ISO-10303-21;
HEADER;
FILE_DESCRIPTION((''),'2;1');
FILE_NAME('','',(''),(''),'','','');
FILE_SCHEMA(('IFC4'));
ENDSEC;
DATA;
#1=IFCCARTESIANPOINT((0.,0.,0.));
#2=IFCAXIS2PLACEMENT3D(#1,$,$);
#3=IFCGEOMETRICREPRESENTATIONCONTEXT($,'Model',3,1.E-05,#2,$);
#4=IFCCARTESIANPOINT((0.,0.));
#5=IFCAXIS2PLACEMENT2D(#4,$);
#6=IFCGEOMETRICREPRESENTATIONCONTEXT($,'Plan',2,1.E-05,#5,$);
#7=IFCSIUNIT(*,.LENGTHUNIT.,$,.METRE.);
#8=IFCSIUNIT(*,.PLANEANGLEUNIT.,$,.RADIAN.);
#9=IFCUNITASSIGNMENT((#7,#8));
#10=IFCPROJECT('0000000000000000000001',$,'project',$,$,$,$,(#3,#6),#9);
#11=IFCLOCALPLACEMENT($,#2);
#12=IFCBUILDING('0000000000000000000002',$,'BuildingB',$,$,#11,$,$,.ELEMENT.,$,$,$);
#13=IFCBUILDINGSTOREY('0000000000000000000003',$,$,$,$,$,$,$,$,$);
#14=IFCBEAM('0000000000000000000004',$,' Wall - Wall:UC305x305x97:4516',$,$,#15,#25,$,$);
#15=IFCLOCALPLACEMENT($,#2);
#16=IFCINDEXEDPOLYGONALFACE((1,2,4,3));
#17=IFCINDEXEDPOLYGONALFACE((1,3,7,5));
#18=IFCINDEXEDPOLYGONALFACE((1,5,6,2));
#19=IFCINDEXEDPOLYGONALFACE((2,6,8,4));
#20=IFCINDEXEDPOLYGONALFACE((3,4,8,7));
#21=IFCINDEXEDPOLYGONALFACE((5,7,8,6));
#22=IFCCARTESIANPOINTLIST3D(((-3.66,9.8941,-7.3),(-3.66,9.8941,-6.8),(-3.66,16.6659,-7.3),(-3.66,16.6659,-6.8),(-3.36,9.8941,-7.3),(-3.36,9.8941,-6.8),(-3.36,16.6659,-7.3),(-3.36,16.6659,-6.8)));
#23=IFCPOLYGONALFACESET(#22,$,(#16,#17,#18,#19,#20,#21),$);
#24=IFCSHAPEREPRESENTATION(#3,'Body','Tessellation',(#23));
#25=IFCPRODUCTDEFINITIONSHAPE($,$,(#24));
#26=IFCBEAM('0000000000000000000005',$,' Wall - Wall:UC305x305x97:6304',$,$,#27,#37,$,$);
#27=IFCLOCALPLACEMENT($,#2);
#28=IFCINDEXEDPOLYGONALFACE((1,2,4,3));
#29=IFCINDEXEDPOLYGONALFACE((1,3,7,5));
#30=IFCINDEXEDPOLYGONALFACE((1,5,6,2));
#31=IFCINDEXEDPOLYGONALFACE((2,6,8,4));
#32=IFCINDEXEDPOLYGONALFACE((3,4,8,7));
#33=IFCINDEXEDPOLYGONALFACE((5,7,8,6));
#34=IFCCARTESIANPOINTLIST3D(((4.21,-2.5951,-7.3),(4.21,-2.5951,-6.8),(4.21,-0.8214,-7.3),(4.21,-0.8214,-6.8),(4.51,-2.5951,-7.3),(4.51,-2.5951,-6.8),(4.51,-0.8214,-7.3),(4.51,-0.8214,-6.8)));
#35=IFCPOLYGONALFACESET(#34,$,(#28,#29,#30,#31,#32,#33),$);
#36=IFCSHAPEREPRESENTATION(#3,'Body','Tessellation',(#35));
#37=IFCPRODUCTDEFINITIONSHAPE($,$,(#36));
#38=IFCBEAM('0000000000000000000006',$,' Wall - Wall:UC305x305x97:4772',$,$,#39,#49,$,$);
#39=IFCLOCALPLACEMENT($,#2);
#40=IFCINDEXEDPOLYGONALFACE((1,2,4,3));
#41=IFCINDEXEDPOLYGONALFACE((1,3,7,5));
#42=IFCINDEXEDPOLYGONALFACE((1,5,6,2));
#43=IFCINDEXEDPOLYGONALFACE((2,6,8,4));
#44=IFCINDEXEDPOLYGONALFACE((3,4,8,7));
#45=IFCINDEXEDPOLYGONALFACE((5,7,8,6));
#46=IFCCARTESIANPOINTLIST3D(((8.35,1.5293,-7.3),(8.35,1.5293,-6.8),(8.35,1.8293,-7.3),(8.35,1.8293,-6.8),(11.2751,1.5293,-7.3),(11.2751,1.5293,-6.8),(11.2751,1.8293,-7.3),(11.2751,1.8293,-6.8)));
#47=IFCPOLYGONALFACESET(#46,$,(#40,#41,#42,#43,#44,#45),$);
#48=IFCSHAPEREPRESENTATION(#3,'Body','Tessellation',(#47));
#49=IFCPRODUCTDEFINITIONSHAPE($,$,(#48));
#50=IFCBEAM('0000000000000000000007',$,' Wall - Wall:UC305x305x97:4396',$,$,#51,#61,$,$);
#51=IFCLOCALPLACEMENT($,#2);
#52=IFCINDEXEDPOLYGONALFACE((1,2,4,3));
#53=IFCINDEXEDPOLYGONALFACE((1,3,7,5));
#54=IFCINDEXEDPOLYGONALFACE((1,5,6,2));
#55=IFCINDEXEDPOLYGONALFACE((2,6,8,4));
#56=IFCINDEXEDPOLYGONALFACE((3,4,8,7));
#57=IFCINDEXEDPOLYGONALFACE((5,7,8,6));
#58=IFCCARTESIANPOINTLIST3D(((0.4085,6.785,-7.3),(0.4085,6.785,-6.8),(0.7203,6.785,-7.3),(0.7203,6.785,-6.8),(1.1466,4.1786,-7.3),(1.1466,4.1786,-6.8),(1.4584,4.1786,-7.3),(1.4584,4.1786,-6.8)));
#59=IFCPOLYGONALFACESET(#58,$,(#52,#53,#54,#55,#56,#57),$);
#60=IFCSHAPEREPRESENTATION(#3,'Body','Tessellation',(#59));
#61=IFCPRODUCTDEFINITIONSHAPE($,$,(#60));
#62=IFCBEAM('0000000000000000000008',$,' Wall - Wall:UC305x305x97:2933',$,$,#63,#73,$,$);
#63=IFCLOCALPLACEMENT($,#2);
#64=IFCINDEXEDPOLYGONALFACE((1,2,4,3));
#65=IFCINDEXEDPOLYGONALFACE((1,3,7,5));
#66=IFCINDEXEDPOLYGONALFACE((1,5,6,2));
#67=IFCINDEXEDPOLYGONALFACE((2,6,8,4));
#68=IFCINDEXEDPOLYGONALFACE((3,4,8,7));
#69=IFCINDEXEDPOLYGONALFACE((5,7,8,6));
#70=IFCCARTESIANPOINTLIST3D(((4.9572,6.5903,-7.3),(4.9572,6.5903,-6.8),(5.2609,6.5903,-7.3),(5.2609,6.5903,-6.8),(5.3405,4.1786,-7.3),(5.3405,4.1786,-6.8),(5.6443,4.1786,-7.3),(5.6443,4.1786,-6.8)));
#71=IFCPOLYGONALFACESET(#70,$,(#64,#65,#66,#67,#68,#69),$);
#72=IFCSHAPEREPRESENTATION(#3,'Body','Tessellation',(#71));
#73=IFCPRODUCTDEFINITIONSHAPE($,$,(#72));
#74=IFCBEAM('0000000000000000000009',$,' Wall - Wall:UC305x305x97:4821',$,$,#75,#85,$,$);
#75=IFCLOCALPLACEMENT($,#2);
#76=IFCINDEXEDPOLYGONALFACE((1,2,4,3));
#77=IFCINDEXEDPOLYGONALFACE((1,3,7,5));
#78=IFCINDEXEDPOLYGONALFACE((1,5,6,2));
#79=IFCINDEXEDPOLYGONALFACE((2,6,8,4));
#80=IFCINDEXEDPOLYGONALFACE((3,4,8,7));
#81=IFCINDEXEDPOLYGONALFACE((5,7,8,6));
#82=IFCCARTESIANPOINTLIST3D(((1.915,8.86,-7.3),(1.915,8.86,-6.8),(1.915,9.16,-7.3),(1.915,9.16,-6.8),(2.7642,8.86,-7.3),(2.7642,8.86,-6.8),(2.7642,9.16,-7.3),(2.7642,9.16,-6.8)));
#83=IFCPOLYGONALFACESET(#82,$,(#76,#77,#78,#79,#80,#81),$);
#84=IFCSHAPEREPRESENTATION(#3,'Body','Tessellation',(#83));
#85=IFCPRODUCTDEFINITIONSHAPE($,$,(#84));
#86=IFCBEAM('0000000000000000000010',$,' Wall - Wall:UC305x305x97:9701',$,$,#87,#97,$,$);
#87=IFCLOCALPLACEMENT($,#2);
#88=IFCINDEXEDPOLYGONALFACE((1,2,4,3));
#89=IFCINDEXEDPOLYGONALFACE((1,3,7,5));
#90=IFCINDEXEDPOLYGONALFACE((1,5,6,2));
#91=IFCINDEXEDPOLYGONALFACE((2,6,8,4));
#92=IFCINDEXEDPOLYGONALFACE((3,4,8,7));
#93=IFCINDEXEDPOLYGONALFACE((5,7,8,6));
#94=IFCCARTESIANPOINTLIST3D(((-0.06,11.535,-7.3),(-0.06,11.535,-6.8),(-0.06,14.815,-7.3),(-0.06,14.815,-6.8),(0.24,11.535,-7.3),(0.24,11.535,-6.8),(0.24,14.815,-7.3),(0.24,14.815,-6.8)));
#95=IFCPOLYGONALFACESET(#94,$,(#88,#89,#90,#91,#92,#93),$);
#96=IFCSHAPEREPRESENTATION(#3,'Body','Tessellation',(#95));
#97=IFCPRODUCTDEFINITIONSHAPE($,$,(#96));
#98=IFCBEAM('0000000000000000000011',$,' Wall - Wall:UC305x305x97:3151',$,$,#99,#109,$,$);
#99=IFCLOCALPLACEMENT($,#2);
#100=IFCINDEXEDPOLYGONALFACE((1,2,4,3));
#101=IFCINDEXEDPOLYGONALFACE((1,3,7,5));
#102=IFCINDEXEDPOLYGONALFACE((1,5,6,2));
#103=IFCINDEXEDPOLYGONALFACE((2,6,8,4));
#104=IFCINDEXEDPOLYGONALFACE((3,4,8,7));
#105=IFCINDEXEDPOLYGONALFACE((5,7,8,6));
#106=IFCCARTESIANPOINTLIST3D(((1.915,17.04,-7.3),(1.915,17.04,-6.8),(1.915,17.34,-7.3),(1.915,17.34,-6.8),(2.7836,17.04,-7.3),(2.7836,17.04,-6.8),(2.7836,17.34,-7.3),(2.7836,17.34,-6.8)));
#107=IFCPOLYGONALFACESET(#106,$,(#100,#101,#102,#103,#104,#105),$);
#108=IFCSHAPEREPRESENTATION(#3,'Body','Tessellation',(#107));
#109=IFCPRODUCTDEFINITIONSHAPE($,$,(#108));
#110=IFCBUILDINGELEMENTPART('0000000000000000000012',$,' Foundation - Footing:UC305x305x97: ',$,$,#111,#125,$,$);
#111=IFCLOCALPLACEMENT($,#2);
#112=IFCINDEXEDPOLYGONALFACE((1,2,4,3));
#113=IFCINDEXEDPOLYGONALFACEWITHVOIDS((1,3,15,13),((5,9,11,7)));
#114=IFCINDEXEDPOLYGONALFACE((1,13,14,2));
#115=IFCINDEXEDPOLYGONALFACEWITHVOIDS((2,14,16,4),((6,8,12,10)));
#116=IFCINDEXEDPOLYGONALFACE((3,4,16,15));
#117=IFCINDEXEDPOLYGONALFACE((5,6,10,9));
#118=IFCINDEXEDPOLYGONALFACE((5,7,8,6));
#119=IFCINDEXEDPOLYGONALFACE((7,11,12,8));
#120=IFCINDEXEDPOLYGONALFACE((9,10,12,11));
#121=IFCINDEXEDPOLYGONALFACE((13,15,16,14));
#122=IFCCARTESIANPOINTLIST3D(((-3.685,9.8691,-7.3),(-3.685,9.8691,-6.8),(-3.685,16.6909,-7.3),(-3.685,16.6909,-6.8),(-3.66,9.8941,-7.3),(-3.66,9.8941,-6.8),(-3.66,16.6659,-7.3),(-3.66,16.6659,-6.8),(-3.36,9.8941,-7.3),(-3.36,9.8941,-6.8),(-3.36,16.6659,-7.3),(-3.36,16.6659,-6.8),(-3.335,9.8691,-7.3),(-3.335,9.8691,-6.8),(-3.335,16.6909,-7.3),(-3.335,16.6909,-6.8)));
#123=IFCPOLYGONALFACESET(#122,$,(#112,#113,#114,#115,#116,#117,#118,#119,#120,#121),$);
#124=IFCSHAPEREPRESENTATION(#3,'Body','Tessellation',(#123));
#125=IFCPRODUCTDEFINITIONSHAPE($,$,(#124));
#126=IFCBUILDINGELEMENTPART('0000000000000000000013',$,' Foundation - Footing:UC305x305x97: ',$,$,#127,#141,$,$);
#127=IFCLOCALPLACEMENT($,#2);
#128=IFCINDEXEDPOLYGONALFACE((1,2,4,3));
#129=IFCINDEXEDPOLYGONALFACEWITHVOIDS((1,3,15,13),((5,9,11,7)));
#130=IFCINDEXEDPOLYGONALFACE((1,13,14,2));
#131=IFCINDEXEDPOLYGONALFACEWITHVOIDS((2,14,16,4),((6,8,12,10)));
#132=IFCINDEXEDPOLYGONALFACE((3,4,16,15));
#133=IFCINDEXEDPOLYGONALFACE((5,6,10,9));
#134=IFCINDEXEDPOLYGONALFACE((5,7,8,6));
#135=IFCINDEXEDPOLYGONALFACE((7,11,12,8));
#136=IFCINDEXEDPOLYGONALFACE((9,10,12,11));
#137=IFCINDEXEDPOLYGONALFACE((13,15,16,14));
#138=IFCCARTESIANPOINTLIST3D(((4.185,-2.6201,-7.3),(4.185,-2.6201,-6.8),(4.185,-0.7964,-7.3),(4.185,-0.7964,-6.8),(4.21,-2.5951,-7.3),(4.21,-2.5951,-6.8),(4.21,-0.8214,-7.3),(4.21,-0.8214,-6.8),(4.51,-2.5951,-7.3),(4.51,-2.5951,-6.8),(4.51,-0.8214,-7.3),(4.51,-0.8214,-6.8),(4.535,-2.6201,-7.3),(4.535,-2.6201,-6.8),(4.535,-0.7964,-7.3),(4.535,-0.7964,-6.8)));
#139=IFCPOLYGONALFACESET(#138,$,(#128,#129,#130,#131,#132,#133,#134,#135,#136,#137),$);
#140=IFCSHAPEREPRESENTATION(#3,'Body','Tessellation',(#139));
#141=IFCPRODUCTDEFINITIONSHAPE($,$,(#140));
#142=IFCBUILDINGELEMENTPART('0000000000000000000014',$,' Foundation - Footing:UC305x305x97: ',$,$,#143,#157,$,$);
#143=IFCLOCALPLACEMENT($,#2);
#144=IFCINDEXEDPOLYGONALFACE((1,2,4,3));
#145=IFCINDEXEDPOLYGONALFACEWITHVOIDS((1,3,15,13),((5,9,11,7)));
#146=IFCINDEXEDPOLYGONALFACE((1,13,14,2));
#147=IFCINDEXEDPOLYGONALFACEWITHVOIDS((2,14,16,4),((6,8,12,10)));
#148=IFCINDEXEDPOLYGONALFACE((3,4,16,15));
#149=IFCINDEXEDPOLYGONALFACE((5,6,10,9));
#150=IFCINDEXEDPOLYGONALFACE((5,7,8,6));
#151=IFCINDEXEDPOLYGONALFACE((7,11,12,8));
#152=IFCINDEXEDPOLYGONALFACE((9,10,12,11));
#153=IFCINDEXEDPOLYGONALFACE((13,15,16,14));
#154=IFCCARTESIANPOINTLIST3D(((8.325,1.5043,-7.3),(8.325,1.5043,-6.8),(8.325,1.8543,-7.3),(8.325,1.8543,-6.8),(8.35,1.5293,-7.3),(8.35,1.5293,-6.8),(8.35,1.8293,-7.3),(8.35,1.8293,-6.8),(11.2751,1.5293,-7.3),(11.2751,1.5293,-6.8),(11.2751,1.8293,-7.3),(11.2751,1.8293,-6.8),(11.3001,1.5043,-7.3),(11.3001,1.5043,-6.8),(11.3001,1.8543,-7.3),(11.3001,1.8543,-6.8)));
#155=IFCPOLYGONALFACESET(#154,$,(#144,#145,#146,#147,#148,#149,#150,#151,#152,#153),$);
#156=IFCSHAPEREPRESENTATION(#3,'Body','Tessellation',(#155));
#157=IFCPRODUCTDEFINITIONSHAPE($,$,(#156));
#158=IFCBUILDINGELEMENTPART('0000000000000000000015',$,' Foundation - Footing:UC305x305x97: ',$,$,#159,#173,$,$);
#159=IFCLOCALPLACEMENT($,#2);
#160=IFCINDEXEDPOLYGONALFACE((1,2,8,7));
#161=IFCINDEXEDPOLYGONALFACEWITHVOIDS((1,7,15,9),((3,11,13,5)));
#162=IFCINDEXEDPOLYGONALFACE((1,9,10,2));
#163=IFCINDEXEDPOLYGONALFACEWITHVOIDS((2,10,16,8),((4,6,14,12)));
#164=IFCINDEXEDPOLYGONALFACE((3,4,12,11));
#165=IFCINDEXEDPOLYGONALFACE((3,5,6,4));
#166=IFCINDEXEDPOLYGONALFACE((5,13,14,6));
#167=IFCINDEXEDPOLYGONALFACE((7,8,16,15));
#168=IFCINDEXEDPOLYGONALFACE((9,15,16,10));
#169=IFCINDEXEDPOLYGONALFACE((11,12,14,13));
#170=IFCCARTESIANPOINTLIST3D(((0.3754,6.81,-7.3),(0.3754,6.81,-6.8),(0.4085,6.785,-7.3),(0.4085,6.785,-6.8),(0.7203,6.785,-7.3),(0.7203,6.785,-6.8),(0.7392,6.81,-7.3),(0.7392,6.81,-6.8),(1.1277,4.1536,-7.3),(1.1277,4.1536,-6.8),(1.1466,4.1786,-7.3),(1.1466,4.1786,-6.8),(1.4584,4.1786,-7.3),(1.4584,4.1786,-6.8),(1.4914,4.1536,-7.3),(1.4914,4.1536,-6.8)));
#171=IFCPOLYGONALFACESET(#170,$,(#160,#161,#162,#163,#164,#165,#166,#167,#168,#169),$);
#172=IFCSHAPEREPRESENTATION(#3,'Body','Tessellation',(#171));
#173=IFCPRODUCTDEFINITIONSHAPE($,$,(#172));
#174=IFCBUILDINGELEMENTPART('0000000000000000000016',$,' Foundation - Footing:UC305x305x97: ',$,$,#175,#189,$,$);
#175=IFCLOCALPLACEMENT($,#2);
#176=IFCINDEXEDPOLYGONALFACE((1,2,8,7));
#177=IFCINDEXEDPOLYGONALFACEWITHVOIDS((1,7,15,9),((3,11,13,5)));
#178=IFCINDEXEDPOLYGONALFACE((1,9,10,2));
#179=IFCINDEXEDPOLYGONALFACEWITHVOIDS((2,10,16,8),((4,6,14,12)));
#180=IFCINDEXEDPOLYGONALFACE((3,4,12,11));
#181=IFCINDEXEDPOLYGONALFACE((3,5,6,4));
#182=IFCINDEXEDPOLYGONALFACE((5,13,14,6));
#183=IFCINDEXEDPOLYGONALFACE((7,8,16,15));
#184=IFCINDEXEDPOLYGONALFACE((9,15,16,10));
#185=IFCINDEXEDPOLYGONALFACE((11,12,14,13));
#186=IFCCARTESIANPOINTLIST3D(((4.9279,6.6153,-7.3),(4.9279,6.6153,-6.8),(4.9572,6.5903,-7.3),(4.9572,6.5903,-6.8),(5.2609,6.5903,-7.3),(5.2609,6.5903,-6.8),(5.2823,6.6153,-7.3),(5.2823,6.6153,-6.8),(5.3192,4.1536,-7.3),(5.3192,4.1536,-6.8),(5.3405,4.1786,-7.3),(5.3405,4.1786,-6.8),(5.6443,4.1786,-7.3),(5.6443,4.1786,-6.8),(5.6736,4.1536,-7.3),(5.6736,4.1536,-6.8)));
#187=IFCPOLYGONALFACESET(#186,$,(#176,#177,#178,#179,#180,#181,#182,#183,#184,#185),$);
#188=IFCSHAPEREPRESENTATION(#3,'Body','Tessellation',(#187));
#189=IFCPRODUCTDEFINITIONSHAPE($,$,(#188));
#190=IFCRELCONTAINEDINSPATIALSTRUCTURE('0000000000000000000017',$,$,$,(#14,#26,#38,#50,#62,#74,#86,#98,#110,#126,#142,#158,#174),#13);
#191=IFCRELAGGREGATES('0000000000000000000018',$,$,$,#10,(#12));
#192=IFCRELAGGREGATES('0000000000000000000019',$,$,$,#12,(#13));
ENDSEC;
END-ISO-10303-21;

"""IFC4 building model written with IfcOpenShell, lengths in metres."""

from ifc_helpers import new_model, si_unit, origin, origin_2d, place, context, project, spatial, polyline, outline, extrude, element, save


model = new_model("IFC4")

# Units and contexts
model_context = context("Model", 3, precision=1e-05, world=origin())
plan_context = context("Plan", 2, precision=1e-05, world=origin_2d())
ifc_project = project(units=[si_unit("LENGTHUNIT", "METRE"), si_unit("PLANEANGLEUNIT", "RADIAN")], contexts=[model_context, plan_context])

# Building, storey
building_placement = place(None, origin())
building = spatial("IfcBuilding", under=ifc_project, at=building_placement, Name="BuildingB", CompositionType="ELEMENT")
storey = spatial("IfcBuildingStorey", under=building)

# Beams
element("IfcBeam", 1, inside=storey, Name=" Wall - Wall:UC305x305x97:4516", context=model_context, shape_type="SweptSolid", body=[
    extrude(outline(polyline([(-3.66, 9.8941, -7.3), (-3.36, 9.8941, -7.3), (-3.36, 16.6659, -7.3), (-3.66, 16.6659, -7.3), (-3.66, 9.8941, -7.3)])), None, (0.0, 0.0, 1.0), 0.5),
])
element("IfcBeam", 2, inside=storey, Name=" Wall - Wall:UC305x305x97:6304", context=model_context, shape_type="SweptSolid", body=[
    extrude(outline(polyline([(4.21, -2.5951, -7.3), (4.51, -2.5951, -7.3), (4.51, -0.8214, -7.3), (4.21, -0.8214, -7.3), (4.21, -2.5951, -7.3)])), None, (0.0, 0.0, 1.0), 0.5),
])
element("IfcBeam", 3, inside=storey, Name=" Wall - Wall:UC305x305x97:4772", context=model_context, shape_type="SweptSolid", body=[
    extrude(outline(polyline([(8.35, 1.5293, -7.3), (8.35, 1.8293, -7.3), (11.2751, 1.8293, -7.3), (11.2751, 1.5293, -7.3), (8.35, 1.5293, -7.3)])), None, (0.0, 0.0, 1.0), 0.5),
])
element("IfcBeam", 4, inside=storey, Name=" Wall - Wall:UC305x305x97:4396", context=model_context, shape_type="SweptSolid", body=[
    extrude(outline(polyline([(1.1466, 4.1786, -7.3), (0.4085, 6.785, -7.3), (0.7203, 6.785, -7.3), (1.4584, 4.1786, -7.3), (1.1466, 4.1786, -7.3)])), None, (0.0, 0.0, 1.0), 0.5),
])
element("IfcBeam", 5, inside=storey, Name=" Wall - Wall:UC305x305x97:2933", context=model_context, shape_type="SweptSolid", body=[
    extrude(outline(polyline([(5.3405, 4.1786, -7.3), (4.9572, 6.5903, -7.3), (5.2609, 6.5903, -7.3), (5.6443, 4.1786, -7.3), (5.3405, 4.1786, -7.3)])), None, (0.0, 0.0, 1.0), 0.5),
])
element("IfcBeam", 6, inside=storey, Name=" Wall - Wall:UC305x305x97:4821", context=model_context, shape_type="SweptSolid", body=[
    extrude(outline(polyline([(1.915, 8.86, -7.3), (1.915, 9.16, -7.3), (2.7642, 9.16, -7.3), (2.7642, 8.86, -7.3), (1.915, 8.86, -7.3)])), None, (0.0, 0.0, 1.0), 0.5),
])
element("IfcBeam", 7, inside=storey, Name=" Wall - Wall:UC305x305x97:9701", context=model_context, shape_type="SweptSolid", body=[
    extrude(outline(polyline([(-0.06, 11.535, -7.3), (-0.06, 14.815, -7.3), (0.24, 14.815, -7.3), (0.24, 11.535, -7.3), (-0.06, 11.535, -7.3)])), None, (0.0, 0.0, 1.0), 0.5),
])
element("IfcBeam", 8, inside=storey, Name=" Wall - Wall:UC305x305x97:3151", context=model_context, shape_type="SweptSolid", body=[
    extrude(outline(polyline([(1.915, 17.04, -7.3), (1.915, 17.34, -7.3), (2.7836, 17.34, -7.3), (2.7836, 17.04, -7.3), (1.915, 17.04, -7.3)])), None, (0.0, 0.0, 1.0), 0.5),
])

# Building element parts, openings
building_element_part_1 = element("IfcBuildingElementPart", 9, inside=storey, Name=" Foundation - Footing:UC305x305x97: ", context=model_context, shape_type="SweptSolid", body=[
    extrude(outline(polyline([(-3.685, 9.8691, -7.3), (-3.335, 9.8691, -7.3), (-3.335, 16.6909, -7.3), (-3.685, 16.6909, -7.3), (-3.685, 9.8691, -7.3)])), None, (0.0, 0.0, 1.0), 0.5),
])
element("IfcOpeningElement", 10, inside=storey, cuts=building_element_part_1, context=model_context, shape_type="SweptSolid", body=[
    extrude(outline(polyline([(-3.66, 9.8941, -7.3), (-3.36, 9.8941, -7.3), (-3.36, 16.6659, -7.3), (-3.66, 16.6659, -7.3), (-3.66, 9.8941, -7.3)])), None, (0.0, 0.0, 1.0), 0.5),
])
building_element_part_2 = element("IfcBuildingElementPart", 11, inside=storey, Name=" Foundation - Footing:UC305x305x97: ", context=model_context, shape_type="SweptSolid", body=[
    extrude(outline(polyline([(4.185, -2.6201, -7.3), (4.535, -2.6201, -7.3), (4.535, -0.7964, -7.3), (4.185, -0.7964, -7.3), (4.185, -2.6201, -7.3)])), None, (0.0, 0.0, 1.0), 0.5),
])
element("IfcOpeningElement", 12, inside=storey, cuts=building_element_part_2, context=model_context, shape_type="SweptSolid", body=[
    extrude(outline(polyline([(4.21, -2.5951, -7.3), (4.51, -2.5951, -7.3), (4.51, -0.8214, -7.3), (4.21, -0.8214, -7.3), (4.21, -2.5951, -7.3)])), None, (0.0, 0.0, 1.0), 0.5),
])
building_element_part_3 = element("IfcBuildingElementPart", 13, inside=storey, Name=" Foundation - Footing:UC305x305x97: ", context=model_context, shape_type="SweptSolid", body=[
    extrude(outline(polyline([(8.325, 1.5043, -7.3), (8.325, 1.8543, -7.3), (11.3001, 1.8543, -7.3), (11.3001, 1.5043, -7.3), (8.325, 1.5043, -7.3)])), None, (0.0, 0.0, 1.0), 0.5),
])
element("IfcOpeningElement", 14, inside=storey, cuts=building_element_part_3, context=model_context, shape_type="SweptSolid", body=[
    extrude(outline(polyline([(8.35, 1.5293, -7.3), (8.35, 1.8293, -7.3), (11.2751, 1.8293, -7.3), (11.2751, 1.5293, -7.3), (8.35, 1.5293, -7.3)])), None, (0.0, 0.0, 1.0), 0.5),
])
building_element_part_4 = element("IfcBuildingElementPart", 15, inside=storey, Name=" Foundation - Footing:UC305x305x97: ", context=model_context, shape_type="SweptSolid", body=[
    extrude(outline(polyline([(1.1277, 4.1536, -7.3), (0.3754, 6.81, -7.3), (0.7392, 6.81, -7.3), (1.4914, 4.1536, -7.3), (1.1277, 4.1536, -7.3)])), None, (0.0, 0.0, 1.0), 0.5),
])
element("IfcOpeningElement", 16, inside=storey, cuts=building_element_part_4, context=model_context, shape_type="SweptSolid", body=[
    extrude(outline(polyline([(1.1466, 4.1786, -7.3), (0.4085, 6.785, -7.3), (0.7203, 6.785, -7.3), (1.4584, 4.1786, -7.3), (1.1466, 4.1786, -7.3)])), None, (0.0, 0.0, 1.0), 0.5),
])
building_element_part_5 = element("IfcBuildingElementPart", 17, inside=storey, Name=" Foundation - Footing:UC305x305x97: ", context=model_context, shape_type="SweptSolid", body=[
    extrude(outline(polyline([(5.3192, 4.1536, -7.3), (4.9279, 6.6153, -7.3), (5.2823, 6.6153, -7.3), (5.6736, 4.1536, -7.3), (5.3192, 4.1536, -7.3)])), None, (0.0, 0.0, 1.0), 0.5),
])
element("IfcOpeningElement", 18, inside=storey, cuts=building_element_part_5, context=model_context, shape_type="SweptSolid", body=[
    extrude(outline(polyline([(5.3405, 4.1786, -7.3), (4.9572, 6.5903, -7.3), (5.2609, 6.5903, -7.3), (5.6443, 4.1786, -7.3), (5.3405, 4.1786, -7.3)])), None, (0.0, 0.0, 1.0), 0.5),
])

save(model, "model.ifc")
